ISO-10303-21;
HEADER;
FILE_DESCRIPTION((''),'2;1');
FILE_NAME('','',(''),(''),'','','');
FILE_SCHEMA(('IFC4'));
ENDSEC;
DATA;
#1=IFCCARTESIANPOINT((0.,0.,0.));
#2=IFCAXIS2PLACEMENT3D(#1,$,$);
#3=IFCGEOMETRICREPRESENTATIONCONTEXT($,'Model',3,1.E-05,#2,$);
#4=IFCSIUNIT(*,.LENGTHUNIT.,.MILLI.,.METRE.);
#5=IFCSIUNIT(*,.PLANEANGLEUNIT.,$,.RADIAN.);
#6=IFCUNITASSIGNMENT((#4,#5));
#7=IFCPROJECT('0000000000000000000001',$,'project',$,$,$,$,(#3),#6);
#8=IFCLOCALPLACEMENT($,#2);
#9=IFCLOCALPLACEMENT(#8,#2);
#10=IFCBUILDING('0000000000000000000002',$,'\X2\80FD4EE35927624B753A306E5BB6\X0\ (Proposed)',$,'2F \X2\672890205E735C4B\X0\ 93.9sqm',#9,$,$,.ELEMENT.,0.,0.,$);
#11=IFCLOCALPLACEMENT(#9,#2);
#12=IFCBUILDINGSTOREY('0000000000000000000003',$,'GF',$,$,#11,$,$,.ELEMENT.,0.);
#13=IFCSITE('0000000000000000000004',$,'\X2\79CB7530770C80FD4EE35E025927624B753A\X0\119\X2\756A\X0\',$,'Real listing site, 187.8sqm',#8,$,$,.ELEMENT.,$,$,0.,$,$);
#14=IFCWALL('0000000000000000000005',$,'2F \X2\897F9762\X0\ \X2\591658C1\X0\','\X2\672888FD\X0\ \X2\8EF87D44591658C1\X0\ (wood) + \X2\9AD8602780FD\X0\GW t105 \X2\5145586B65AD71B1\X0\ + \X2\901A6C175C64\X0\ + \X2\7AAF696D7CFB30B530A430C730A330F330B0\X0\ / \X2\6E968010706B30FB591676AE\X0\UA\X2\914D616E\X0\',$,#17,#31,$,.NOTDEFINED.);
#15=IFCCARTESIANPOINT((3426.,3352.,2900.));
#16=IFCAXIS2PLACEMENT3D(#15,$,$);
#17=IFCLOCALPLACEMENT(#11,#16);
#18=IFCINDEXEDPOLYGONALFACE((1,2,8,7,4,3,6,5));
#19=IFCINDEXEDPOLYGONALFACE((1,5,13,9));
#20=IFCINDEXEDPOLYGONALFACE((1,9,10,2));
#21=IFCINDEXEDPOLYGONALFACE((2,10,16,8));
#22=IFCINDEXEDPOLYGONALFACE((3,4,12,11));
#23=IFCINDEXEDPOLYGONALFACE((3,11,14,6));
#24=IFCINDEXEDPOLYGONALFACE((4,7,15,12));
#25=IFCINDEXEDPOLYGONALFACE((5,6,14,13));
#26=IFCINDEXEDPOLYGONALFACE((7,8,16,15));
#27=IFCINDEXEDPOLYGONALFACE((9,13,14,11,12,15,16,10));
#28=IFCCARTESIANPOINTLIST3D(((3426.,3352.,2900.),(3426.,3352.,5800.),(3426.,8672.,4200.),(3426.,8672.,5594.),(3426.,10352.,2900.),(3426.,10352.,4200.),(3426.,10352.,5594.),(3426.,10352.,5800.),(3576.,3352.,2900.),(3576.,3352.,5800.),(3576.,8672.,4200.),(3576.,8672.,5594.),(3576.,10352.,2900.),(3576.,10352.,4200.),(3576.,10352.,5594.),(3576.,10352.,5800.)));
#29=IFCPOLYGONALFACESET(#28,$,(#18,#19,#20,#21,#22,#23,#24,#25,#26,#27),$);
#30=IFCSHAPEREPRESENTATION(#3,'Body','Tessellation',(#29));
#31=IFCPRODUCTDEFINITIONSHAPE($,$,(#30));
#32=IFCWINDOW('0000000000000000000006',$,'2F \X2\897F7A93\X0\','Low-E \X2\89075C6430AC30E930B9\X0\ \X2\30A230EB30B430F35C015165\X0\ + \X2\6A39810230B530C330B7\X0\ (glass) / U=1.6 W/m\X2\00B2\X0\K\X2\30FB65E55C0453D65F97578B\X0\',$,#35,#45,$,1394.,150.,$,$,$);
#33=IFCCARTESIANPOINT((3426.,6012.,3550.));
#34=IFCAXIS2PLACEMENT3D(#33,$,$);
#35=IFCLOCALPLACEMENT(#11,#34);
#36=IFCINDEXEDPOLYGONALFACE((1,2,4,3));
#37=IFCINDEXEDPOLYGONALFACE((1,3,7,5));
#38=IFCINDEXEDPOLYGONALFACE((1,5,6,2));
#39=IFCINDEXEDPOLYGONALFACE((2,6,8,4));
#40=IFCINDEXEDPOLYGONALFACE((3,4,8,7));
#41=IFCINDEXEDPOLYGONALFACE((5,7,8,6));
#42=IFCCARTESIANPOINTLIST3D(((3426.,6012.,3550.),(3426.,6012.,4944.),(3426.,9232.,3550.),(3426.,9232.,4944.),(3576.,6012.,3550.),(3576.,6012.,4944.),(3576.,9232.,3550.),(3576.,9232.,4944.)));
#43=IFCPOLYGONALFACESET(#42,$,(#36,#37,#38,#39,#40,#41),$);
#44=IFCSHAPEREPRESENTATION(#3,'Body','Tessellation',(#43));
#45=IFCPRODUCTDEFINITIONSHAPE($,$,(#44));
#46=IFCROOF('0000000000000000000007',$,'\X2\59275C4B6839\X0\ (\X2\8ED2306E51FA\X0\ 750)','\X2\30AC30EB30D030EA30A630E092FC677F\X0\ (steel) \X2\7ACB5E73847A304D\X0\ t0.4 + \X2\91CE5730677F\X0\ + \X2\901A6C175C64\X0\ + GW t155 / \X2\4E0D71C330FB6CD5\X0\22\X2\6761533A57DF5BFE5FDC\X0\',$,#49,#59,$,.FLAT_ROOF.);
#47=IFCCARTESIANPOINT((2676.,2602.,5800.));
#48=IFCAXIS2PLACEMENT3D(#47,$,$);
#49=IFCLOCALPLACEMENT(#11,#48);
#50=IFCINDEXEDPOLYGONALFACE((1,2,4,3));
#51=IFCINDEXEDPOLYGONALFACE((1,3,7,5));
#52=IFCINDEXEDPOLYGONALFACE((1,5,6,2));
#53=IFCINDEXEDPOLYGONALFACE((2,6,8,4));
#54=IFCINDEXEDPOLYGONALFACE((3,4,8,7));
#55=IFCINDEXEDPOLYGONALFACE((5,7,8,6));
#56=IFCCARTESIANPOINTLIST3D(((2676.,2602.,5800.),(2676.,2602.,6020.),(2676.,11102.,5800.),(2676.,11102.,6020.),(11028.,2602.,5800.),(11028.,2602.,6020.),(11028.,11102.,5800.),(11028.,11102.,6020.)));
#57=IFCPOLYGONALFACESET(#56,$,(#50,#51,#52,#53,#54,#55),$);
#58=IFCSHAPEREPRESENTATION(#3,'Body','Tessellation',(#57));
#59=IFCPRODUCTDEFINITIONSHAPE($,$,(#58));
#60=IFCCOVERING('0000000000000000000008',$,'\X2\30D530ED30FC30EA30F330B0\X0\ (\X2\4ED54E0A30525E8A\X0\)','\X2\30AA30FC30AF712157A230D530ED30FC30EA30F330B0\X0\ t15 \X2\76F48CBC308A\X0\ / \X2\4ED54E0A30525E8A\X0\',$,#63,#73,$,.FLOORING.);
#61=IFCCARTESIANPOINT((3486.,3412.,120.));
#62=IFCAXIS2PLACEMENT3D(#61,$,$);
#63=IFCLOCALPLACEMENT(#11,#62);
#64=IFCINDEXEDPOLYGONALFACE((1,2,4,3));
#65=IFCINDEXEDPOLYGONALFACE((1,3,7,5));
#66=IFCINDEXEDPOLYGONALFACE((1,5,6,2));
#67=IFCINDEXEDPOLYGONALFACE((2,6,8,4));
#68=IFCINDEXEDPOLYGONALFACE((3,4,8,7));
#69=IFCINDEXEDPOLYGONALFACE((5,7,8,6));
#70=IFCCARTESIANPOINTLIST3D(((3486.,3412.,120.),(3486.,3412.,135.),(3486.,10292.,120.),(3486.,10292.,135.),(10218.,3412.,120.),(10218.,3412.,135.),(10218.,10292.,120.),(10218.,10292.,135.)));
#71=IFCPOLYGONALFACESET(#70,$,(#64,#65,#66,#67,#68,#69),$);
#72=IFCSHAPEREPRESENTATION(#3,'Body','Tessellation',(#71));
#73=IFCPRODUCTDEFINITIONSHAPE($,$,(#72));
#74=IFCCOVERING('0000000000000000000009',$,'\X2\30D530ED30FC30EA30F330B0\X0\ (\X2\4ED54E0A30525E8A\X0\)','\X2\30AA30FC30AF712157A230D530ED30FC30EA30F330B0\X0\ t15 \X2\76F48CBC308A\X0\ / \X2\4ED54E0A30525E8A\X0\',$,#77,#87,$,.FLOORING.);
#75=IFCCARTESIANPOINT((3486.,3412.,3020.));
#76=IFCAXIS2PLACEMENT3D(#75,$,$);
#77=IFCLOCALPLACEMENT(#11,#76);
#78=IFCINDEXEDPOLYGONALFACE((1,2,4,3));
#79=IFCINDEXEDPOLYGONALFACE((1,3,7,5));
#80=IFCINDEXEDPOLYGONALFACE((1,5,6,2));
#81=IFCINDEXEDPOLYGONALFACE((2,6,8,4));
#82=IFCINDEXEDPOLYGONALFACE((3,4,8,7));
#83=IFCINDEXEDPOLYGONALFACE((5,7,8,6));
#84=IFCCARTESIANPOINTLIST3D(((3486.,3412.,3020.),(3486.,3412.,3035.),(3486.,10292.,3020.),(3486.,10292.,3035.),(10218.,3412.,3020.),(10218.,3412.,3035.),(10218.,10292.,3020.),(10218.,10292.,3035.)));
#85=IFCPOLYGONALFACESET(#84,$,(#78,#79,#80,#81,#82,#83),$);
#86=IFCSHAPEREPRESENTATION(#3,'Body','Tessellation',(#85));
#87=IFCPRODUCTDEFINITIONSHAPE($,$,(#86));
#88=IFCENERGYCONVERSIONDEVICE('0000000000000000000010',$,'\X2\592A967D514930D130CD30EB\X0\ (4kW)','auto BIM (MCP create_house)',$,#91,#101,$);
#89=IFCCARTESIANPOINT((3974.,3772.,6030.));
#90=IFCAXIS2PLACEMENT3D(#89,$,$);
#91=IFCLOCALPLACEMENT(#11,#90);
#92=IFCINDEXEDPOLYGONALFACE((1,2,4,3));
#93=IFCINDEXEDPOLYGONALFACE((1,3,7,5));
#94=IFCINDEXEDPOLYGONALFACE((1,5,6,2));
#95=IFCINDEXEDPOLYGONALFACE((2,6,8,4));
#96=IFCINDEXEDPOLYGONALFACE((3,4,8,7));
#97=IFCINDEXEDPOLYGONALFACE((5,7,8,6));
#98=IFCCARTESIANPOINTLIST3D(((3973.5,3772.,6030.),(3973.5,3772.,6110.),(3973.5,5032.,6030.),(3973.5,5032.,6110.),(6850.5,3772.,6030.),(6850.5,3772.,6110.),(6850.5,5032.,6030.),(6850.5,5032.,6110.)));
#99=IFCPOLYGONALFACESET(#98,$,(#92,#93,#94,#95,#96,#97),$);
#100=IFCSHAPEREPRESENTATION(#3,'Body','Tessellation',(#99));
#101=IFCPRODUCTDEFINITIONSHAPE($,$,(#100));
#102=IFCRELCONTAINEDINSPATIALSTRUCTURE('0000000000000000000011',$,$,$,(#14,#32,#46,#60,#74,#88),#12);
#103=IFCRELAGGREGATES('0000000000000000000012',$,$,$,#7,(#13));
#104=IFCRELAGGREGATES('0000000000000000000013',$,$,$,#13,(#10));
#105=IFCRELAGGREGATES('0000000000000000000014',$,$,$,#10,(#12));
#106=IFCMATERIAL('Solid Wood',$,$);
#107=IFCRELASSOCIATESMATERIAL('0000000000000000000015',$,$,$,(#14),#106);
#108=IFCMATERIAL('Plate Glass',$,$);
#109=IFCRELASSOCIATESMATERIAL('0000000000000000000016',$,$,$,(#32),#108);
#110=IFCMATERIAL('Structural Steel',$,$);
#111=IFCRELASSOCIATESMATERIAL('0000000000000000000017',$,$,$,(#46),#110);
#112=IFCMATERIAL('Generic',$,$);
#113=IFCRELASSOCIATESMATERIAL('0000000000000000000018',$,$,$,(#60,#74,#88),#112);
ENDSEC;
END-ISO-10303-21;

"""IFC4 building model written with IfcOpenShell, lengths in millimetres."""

from ifc_helpers import new_model, si_unit, frame, frame_2d, origin, place, context, project, spatial, rectangle, extrude, material, element, fill, save


model = new_model("IFC4")

# Units and contexts
model_context = context("Model", 3, precision=1e-05, world=origin())
ifc_project = project(units=[si_unit("LENGTHUNIT", "METRE", prefix="MILLI"), si_unit("PLANEANGLEUNIT", "RADIAN")], contexts=[model_context])

# Site, building, storey
site_placement = place(None, origin())
site = spatial("IfcSite", under=ifc_project, at=site_placement, Name="秋田県能代市大手町119番", ObjectType="Real listing site, 187.8sqm", CompositionType="ELEMENT", RefElevation=0.0)
building_placement = place(site_placement, origin())
building = spatial("IfcBuilding", under=site, at=building_placement, Name="能代大手町の家 (Proposed)", ObjectType="2F 木造平屋 93.9sqm", CompositionType="ELEMENT", ElevationOfRefHeight=0.0, ElevationOfTerrain=0.0)
storey_placement = place(building_placement, origin())
storey = spatial("IfcBuildingStorey", under=building, at=storey_placement, Name="GF", CompositionType="ELEMENT", Elevation=0.0)

# Shared definitions
ifc_material_1 = material(Name="Solid Wood")

# Shared definitions
ifc_material_2 = material(Name="Plate Glass")

# Wall, opening, window
wall_1_placement = place(storey_placement, frame((3426.0, 3352.0, 2900.0)))
wall_1 = element("IfcWall", 1, at=wall_1_placement, inside=storey, material=ifc_material_1, Name="2F 西面 外壁", Description="木製 軸組外壁 (wood) + 高性能GW t105 充填断熱 + 通気層 + 窯業系サイディング / 準耐火・外皮UA配慮", PredefinedType="NOTDEFINED", context=model_context, shape_type="SweptSolid", body=[
    extrude(rectangle(XDim=150.0, YDim=7000.0, at=frame_2d((75.0, 3500.0))), frame((3426.0, 3352.0, 2900.0)), (0.0, 0.0, 1.0), 2900.0),
])
opening_1_placement = place(storey_placement, frame((3426.0, 6012.0, 3550.0)))
opening_1 = element("IfcOpeningElement", 2, at=opening_1_placement, cuts=wall_1, PredefinedType="NOTDEFINED", context=model_context, shape_type="SweptSolid", body=[
    extrude(rectangle(XDim=150.0, YDim=3220.0, at=frame_2d((75.0, 1610.0))), frame((3426.0, 6012.0, 3550.0)), (0.0, 0.0, 1.0), 1394.0),
])
window_1_placement = place(storey_placement, frame((3426.0, 6012.0, 3550.0)))
window_1 = element("IfcWindow", 3, at=window_1_placement, inside=storey, material=ifc_material_2, Name="2F 西窓", Description="Low-E 複層ガラス アルゴン封入 + 樹脂サッシ (glass) / U=1.6 W/m²K・日射取得型", OverallHeight=1394.0, OverallWidth=150.0, context=model_context, shape_type="SweptSolid", body=[
    extrude(rectangle(XDim=150.0, YDim=3220.0, at=frame_2d((75.0, 1610.0))), frame((3426.0, 6012.0, 3550.0)), (0.0, 0.0, 1.0), 1394.0),
])
fill(opening_1, window_1)

# Roof
ifc_material_3 = material(Name="Structural Steel")
roof_placement = place(storey_placement, frame((2676.0, 2602.0, 5800.0)))
element("IfcRoof", 4, at=roof_placement, inside=storey, material=ifc_material_3, Name="大屋根 (軒の出 750)", Description="ガルバリウム鋼板 (steel) 立平葺き t0.4 + 野地板 + 通気層 + GW t155 / 不燃・法22条区域対応", PredefinedType="FLAT_ROOF", context=model_context, shape_type="SweptSolid", body=[
    extrude(rectangle(XDim=8352.0, YDim=8500.0, at=frame_2d((4176.0, 4250.0))), frame((2676.0, 2602.0, 5800.0)), (0.0, 0.0, 1.0), 220.0),
])

# Coverings
ifc_material_4 = material(Name="Generic")
covering_1_placement = place(storey_placement, frame((3486.0, 3412.0, 120.0)))
element("IfcCovering", 5, at=covering_1_placement, inside=storey, material=ifc_material_4, Name="フローリング (仕上げ床)", Description="オーク無垢フローリング t15 直貼り / 仕上げ床", PredefinedType="FLOORING", context=model_context, shape_type="SweptSolid", body=[
    extrude(rectangle(XDim=6732.0, YDim=6880.0, at=frame_2d((3366.0, 3440.0))), frame((3486.0, 3412.0, 120.0)), (0.0, 0.0, 1.0), 15.0),
])
covering_2_placement = place(storey_placement, frame((3486.0, 3412.0, 3020.0)))
element("IfcCovering", 6, at=covering_2_placement, inside=storey, material=ifc_material_4, Name="フローリング (仕上げ床)", Description="オーク無垢フローリング t15 直貼り / 仕上げ床", PredefinedType="FLOORING", context=model_context, shape_type="SweptSolid", body=[
    extrude(rectangle(XDim=6732.0, YDim=6880.0, at=frame_2d((3366.0, 3440.0))), frame((3486.0, 3412.0, 3020.0)), (0.0, 0.0, 1.0), 15.0),
])

# Energy conversion device
energy_conversion_device_placement = place(storey_placement, frame((3974.0, 3772.0, 6030.0)))
element("IfcEnergyConversionDevice", 7, at=energy_conversion_device_placement, inside=storey, material=ifc_material_4, Name="太陽光パネル (4kW)", Description="auto BIM (MCP create_house)", context=model_context, shape_type="SweptSolid", body=[
    extrude(rectangle(XDim=2877.0, YDim=1260.0, at=frame_2d((1438.0, 630.0))), frame((3974.0, 3772.0, 6030.0)), (0.0, 0.0, 1.0), 80.0),
])

save(model, "model.ifc")
